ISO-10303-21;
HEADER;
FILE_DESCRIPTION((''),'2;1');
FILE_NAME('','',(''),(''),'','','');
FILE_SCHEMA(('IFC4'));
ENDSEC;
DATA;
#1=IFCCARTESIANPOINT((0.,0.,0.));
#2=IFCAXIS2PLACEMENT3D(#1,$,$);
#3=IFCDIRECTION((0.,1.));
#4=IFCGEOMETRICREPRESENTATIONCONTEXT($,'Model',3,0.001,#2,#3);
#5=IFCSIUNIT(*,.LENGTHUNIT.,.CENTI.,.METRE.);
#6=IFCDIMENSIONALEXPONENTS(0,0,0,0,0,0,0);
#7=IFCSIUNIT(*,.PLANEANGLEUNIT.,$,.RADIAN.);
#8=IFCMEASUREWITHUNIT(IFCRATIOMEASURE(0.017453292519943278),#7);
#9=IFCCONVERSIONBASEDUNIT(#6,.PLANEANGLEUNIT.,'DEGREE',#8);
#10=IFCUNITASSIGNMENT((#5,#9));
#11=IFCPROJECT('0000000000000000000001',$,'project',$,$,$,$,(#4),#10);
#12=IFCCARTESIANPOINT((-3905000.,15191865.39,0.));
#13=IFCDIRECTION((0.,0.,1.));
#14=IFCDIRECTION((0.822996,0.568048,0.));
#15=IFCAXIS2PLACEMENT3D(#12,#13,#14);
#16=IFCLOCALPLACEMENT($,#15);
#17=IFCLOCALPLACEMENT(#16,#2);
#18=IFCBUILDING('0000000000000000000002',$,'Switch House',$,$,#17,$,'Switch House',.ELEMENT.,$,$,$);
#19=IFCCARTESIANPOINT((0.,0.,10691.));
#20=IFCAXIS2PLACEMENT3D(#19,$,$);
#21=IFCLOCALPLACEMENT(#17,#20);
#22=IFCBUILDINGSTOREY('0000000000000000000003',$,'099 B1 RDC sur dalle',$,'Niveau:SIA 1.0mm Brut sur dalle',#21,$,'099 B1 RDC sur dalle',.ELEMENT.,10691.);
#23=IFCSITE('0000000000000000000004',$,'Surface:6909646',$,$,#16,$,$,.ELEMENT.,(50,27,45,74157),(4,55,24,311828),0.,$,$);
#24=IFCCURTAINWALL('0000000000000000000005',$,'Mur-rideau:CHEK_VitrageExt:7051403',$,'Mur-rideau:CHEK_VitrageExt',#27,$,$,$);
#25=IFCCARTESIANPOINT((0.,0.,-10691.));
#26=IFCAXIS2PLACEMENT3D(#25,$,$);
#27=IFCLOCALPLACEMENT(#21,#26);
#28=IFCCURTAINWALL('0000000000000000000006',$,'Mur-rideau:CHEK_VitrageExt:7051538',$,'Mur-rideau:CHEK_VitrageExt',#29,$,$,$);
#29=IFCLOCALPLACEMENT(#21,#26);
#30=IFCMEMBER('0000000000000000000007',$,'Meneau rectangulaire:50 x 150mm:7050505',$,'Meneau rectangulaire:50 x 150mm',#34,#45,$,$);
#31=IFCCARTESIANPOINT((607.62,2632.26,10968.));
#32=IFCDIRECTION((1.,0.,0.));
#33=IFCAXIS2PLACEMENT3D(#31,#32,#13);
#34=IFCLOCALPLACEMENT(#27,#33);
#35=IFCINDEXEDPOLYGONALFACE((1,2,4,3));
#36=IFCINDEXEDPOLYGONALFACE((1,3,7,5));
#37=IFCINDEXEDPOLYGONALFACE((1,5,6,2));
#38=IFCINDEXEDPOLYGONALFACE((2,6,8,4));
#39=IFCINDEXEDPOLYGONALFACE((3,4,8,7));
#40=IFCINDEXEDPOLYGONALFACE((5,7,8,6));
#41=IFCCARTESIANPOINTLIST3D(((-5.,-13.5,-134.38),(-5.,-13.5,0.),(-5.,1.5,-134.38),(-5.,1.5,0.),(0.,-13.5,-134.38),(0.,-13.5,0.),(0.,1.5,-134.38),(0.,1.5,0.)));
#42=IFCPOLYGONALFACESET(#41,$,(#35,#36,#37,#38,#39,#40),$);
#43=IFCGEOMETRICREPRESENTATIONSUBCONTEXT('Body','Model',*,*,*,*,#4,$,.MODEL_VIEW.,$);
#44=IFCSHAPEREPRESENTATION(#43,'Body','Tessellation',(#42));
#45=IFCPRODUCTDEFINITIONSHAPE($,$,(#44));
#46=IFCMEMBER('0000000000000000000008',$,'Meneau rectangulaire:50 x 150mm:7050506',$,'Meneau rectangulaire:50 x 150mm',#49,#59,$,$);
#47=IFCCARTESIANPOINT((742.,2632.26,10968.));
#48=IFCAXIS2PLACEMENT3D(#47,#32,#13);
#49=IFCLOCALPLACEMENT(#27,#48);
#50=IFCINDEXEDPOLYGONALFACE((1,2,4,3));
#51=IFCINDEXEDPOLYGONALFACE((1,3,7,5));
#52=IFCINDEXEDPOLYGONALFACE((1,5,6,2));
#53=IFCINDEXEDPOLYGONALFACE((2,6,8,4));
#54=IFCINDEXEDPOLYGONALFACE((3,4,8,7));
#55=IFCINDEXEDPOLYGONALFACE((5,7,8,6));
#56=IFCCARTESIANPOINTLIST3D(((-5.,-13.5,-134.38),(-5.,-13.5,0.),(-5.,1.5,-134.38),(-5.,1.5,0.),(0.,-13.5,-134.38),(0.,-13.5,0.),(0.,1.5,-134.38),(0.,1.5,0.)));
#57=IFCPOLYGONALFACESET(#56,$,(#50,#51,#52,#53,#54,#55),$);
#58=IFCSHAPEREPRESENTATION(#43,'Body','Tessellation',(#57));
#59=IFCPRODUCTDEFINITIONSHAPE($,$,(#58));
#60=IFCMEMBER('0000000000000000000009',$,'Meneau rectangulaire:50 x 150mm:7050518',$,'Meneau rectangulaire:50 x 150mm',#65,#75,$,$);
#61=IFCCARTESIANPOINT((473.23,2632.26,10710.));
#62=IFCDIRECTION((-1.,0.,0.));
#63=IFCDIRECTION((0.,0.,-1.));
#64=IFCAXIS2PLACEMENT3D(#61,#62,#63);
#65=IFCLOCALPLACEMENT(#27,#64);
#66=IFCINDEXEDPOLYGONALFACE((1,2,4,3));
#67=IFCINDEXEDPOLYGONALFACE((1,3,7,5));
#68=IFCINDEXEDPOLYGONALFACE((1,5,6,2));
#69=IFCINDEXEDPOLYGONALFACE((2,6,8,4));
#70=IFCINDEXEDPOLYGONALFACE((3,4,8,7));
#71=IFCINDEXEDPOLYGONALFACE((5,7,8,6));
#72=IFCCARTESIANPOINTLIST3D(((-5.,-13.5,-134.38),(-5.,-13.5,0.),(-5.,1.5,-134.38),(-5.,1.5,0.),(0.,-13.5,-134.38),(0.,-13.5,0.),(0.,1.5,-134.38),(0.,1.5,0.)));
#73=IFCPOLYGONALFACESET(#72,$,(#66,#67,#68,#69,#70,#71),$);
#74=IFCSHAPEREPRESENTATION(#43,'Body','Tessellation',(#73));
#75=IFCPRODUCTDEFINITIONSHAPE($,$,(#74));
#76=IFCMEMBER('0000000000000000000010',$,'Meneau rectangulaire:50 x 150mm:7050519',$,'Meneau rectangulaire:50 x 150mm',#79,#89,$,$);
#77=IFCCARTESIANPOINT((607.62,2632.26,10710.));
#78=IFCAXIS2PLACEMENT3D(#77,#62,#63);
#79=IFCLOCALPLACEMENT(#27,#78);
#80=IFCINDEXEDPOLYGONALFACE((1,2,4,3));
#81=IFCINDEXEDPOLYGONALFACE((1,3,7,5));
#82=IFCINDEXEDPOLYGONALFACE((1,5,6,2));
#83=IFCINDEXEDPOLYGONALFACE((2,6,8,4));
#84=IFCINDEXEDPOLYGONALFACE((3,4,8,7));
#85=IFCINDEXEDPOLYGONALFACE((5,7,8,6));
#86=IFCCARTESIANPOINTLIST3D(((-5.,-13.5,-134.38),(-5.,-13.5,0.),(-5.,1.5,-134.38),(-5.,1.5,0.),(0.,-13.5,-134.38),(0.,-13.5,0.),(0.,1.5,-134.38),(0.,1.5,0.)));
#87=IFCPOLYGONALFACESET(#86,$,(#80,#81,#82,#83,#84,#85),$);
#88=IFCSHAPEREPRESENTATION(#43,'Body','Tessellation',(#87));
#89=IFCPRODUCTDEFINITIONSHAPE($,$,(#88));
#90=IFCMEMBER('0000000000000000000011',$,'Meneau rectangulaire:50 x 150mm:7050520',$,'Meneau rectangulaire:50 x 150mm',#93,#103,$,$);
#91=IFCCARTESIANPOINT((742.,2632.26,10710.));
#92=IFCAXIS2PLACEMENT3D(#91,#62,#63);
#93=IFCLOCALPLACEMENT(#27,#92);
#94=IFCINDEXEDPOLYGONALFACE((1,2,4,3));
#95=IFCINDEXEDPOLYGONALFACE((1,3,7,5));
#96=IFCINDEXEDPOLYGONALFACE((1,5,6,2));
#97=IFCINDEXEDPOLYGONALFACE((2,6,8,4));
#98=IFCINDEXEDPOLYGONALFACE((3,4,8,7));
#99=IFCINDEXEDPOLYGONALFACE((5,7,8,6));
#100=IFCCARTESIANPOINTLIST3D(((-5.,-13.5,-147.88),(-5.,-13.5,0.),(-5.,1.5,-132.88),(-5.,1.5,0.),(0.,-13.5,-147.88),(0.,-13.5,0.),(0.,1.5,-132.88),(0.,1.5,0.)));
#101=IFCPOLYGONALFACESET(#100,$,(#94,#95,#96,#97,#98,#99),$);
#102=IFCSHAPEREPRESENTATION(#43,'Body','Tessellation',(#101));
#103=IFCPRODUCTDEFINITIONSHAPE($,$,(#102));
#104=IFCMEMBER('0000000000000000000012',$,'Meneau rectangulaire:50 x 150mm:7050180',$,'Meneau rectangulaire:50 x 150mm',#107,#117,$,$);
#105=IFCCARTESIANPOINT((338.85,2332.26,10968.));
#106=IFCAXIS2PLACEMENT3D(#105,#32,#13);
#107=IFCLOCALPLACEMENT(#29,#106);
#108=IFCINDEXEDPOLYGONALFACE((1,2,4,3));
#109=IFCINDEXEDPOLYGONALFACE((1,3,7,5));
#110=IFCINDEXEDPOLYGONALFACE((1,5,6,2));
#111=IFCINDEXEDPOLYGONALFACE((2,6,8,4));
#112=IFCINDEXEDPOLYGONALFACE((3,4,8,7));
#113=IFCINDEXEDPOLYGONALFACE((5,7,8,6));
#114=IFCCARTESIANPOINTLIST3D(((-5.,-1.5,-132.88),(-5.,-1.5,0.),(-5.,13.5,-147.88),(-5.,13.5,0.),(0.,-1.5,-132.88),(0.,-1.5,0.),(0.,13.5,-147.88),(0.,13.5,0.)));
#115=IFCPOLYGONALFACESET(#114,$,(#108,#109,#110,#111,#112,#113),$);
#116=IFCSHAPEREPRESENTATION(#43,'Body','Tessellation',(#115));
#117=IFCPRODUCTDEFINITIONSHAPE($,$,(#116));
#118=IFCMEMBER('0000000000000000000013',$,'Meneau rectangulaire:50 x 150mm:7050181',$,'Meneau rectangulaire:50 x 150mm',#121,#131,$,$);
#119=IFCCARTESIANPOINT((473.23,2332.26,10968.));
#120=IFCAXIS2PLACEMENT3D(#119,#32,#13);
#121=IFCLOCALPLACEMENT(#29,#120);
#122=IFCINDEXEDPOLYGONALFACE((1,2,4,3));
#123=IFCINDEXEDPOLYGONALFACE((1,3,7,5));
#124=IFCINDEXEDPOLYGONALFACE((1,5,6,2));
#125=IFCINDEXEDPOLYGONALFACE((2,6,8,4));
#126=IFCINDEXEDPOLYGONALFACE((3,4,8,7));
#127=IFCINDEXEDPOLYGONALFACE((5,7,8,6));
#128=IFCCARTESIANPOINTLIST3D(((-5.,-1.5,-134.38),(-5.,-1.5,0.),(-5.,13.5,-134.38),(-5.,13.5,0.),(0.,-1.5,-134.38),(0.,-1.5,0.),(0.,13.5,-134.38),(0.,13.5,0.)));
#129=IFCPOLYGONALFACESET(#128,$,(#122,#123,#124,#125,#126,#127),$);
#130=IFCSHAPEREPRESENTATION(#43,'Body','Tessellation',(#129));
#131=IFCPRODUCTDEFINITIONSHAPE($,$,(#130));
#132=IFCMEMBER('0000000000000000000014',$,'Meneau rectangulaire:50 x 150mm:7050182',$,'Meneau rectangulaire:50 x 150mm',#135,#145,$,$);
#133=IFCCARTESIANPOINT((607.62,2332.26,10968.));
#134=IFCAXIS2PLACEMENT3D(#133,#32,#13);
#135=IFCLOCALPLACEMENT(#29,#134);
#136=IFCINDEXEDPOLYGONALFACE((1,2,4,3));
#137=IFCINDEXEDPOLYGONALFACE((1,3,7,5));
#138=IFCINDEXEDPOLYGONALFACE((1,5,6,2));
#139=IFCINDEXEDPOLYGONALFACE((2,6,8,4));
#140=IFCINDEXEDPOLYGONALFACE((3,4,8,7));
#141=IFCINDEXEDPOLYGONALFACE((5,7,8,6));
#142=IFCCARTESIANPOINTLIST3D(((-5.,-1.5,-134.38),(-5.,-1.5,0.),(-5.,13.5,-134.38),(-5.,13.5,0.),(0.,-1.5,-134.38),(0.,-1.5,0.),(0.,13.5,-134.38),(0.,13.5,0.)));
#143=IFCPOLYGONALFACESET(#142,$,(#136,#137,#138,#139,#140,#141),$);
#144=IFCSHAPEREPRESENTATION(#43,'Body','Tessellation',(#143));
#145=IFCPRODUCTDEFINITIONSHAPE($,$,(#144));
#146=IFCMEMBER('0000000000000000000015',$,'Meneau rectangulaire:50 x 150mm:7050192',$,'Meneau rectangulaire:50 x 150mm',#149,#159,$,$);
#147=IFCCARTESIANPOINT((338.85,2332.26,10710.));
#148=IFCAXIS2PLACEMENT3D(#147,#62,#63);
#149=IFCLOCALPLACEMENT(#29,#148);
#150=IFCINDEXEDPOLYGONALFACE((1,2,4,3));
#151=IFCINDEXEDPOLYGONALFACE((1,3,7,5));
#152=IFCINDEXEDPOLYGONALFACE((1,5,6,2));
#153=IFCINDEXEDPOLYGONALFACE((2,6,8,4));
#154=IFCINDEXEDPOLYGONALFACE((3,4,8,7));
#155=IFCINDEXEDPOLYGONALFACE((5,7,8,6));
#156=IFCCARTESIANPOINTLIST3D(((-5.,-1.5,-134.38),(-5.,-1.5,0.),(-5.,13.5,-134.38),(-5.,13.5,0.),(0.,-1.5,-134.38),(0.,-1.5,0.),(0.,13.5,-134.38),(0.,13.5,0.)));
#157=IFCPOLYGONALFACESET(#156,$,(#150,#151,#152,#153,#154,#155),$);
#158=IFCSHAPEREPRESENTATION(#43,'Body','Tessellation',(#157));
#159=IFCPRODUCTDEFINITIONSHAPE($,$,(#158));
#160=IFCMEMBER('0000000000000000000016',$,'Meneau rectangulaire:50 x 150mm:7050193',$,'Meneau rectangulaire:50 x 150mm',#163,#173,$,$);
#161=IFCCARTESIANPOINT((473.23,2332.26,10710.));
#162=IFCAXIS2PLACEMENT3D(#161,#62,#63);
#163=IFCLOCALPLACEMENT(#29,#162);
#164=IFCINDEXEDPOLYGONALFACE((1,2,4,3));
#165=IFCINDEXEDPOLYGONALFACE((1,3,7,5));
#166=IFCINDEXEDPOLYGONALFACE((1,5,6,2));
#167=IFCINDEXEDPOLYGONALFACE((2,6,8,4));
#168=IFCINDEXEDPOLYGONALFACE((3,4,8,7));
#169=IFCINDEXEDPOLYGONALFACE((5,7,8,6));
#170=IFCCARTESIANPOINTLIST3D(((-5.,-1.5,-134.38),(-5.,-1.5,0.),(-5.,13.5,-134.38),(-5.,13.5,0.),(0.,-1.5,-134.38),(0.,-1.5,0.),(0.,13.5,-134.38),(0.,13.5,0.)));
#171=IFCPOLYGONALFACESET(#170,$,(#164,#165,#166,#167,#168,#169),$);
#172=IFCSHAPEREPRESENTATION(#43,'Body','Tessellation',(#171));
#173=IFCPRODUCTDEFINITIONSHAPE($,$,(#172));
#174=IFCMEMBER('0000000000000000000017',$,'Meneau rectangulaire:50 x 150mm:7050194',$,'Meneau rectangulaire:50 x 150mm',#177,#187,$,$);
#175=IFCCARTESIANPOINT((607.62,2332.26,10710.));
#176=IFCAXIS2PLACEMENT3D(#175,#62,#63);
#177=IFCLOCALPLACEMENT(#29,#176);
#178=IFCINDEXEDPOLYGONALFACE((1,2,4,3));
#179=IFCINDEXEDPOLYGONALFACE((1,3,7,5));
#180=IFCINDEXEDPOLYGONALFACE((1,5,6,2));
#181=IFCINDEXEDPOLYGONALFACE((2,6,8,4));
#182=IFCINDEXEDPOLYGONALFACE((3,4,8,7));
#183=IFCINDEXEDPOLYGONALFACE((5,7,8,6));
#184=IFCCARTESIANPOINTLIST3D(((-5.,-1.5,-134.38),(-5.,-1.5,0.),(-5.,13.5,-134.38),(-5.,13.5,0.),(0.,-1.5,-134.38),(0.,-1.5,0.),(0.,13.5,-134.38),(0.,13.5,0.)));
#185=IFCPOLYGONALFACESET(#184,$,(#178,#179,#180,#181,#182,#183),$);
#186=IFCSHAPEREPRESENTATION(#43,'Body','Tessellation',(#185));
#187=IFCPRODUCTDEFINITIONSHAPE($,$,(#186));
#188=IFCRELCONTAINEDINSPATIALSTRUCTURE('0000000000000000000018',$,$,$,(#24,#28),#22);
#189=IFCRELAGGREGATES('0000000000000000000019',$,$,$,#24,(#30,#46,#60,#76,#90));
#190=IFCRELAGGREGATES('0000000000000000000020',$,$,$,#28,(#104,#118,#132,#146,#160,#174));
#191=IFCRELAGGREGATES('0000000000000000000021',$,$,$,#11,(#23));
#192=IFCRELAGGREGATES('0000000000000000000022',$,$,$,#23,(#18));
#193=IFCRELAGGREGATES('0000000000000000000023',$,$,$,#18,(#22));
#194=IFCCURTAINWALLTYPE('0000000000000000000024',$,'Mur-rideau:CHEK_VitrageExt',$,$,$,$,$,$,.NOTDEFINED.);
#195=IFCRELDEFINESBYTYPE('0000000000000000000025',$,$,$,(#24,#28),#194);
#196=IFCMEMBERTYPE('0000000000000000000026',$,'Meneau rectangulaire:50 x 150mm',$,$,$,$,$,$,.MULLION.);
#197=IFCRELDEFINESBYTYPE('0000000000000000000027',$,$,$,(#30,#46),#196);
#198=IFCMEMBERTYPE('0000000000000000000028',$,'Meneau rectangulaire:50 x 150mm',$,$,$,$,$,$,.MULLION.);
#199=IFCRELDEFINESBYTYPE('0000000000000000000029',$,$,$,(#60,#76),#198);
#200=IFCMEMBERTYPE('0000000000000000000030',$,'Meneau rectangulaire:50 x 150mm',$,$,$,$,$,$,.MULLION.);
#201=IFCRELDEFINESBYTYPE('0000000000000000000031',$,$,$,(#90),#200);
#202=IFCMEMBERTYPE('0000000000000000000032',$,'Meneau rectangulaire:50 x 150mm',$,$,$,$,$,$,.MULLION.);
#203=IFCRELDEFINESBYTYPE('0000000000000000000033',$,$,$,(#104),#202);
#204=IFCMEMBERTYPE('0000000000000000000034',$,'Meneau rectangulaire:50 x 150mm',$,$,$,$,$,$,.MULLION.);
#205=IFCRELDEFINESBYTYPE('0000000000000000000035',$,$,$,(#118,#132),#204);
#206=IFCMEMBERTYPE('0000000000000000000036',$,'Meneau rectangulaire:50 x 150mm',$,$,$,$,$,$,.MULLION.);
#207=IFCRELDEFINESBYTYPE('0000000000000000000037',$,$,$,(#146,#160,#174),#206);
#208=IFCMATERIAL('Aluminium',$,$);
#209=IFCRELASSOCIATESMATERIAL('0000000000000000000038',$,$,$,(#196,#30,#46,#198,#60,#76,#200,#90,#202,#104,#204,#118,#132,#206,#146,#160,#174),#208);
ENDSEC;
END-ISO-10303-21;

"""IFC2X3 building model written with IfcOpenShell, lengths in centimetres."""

from ifc_helpers import new_model, entity, si_unit, converted_unit, direction, frame, origin, origin_2d_with_axis, place, context, subcontext, project, spatial, rectangle, extrude, clip, halfspace, source, transform, mapped, material, type_object, type_shapes, element, aggregate, save


model = new_model("IFC2X3")

# Units and contexts
model_context = context("Model", 3, precision=0.001, world=origin(), true_north=direction((0.0, 1.0)))
body_context = subcontext(model_context, "Body", "Model", "MODEL_VIEW")
ifc_project = project(units=[si_unit("LENGTHUNIT", "METRE", prefix="CENTI"), converted_unit("PLANEANGLEUNIT", "DEGREE", entity("IfcRatioMeasure", 0.017453292519943278), si_unit("PLANEANGLEUNIT", "RADIAN"), dimensions=[0, 0, 0, 0, 0, 0, 0])], contexts=[model_context])

# Site, building, storey
site_placement = place(None, frame((-3905000.0, 15191865.39, 0.0), z_axis=(0.0, 0.0, 1.0), x_axis=(0.822996, 0.568048, 0.0)))
site = spatial("IfcSite", under=ifc_project, at=site_placement, Name="Surface:6909646", CompositionType="ELEMENT", RefLatitude=(50, 27, 45, 74157), RefLongitude=(4, 55, 24, 311828), RefElevation=0.0)
building_placement = place(site_placement, origin())
building = spatial("IfcBuilding", under=site, at=building_placement, Name="Switch House", LongName="Switch House", CompositionType="ELEMENT")
storey_placement = place(building_placement, frame((0.0, 0.0, 10691.0)))
storey = spatial("IfcBuildingStorey", under=building, at=storey_placement, Name="099 B1 RDC sur dalle", ObjectType="Niveau:SIA 1.0mm Brut sur dalle", LongName="099 B1 RDC sur dalle", CompositionType="ELEMENT", Elevation=10691.0)

# Shared definitions
curtain_wall_type = type_object("IfcCurtainWallType", Name="Mur-rideau:CHEK_VitrageExt", PredefinedType="NOTDEFINED")
ifc_material_1 = material(Name="Aluminium")

# Curtain walls
curtain_wall_1_placement = place(storey_placement, frame((0.0, 0.0, -10691.0)))
curtain_wall_1 = element("IfcCurtainWall", 1, at=curtain_wall_1_placement, inside=storey, type_object=curtain_wall_type, Name="Mur-rideau:CHEK_VitrageExt:7051403", ObjectType="Mur-rideau:CHEK_VitrageExt")
curtain_wall_2_placement = place(storey_placement, frame((0.0, 0.0, -10691.0)))
curtain_wall_2 = element("IfcCurtainWall", 2, at=curtain_wall_2_placement, inside=storey, type_object=curtain_wall_type, Name="Mur-rideau:CHEK_VitrageExt:7051538", ObjectType="Mur-rideau:CHEK_VitrageExt")

# Members
member_type_1 = type_object("IfcMemberType", Name="Meneau rectangulaire:50 x 150mm", PredefinedType="MULLION", material=ifc_material_1)
shared_shape_1 = source(origin(), body_context, "Body", "SweptSolid", [
    extrude(rectangle(XDim=15.0, YDim=5.0, at=origin_2d_with_axis()), frame((-2.5, -6.0, -134.38), z_axis=(0.0, 0.0, 1.0), x_axis=(0.0, -1.0, 0.0)), (0.0, 0.0, 1.0), 134.38),
])
type_shapes(member_type_1, [shared_shape_1])
member_1_placement = place(curtain_wall_1_placement, frame((607.62, 2632.26, 10968.0), z_axis=(1.0, 0.0, 0.0), x_axis=(0.0, 0.0, 1.0)))
member_1 = element("IfcMember", 3, at=member_1_placement, type_object=member_type_1, material=ifc_material_1, Name="Meneau rectangulaire:50 x 150mm:7050505", ObjectType="Meneau rectangulaire:50 x 150mm", context=body_context, shape_type="MappedRepresentation", body=[
    mapped(shared_shape_1, transform((0.0, 0.0, 0.0), scale=1.0)),
])
member_2_placement = place(curtain_wall_1_placement, frame((742.0, 2632.26, 10968.0), z_axis=(1.0, 0.0, 0.0), x_axis=(0.0, 0.0, 1.0)))
member_2 = element("IfcMember", 4, at=member_2_placement, type_object=member_type_1, material=ifc_material_1, Name="Meneau rectangulaire:50 x 150mm:7050506", ObjectType="Meneau rectangulaire:50 x 150mm", context=body_context, shape_type="MappedRepresentation", body=[
    mapped(shared_shape_1, transform((0.0, 0.0, 0.0), scale=1.0)),
])
member_type_2 = type_object("IfcMemberType", Name="Meneau rectangulaire:50 x 150mm", PredefinedType="MULLION", material=ifc_material_1)
shared_shape_2 = source(origin(), body_context, "Body", "SweptSolid", [
    extrude(rectangle(XDim=15.0, YDim=5.0, at=origin_2d_with_axis()), frame((-2.5, -6.0, -134.38), z_axis=(0.0, 0.0, 1.0), x_axis=(0.0, -1.0, 0.0)), (0.0, 0.0, 1.0), 134.38),
])
type_shapes(member_type_2, [shared_shape_2])
member_3_placement = place(curtain_wall_1_placement, frame((473.23, 2632.26, 10710.0), z_axis=(-1.0, 0.0, 0.0), x_axis=(0.0, 0.0, -1.0)))
member_3 = element("IfcMember", 5, at=member_3_placement, type_object=member_type_2, material=ifc_material_1, Name="Meneau rectangulaire:50 x 150mm:7050518", ObjectType="Meneau rectangulaire:50 x 150mm", context=body_context, shape_type="MappedRepresentation", body=[
    mapped(shared_shape_2, transform((0.0, 0.0, 0.0), scale=1.0)),
])
member_4_placement = place(curtain_wall_1_placement, frame((607.62, 2632.26, 10710.0), z_axis=(-1.0, 0.0, 0.0), x_axis=(0.0, 0.0, -1.0)))
member_4 = element("IfcMember", 6, at=member_4_placement, type_object=member_type_2, material=ifc_material_1, Name="Meneau rectangulaire:50 x 150mm:7050519", ObjectType="Meneau rectangulaire:50 x 150mm", context=body_context, shape_type="MappedRepresentation", body=[
    mapped(shared_shape_2, transform((0.0, 0.0, 0.0), scale=1.0)),
])
member_type_3 = type_object("IfcMemberType", Name="Meneau rectangulaire:50 x 150mm", PredefinedType="MULLION", material=ifc_material_1)
shared_shape_3 = source(origin(), body_context, "Body", "SweptSolid", [
    clip(extrude(rectangle(XDim=15.0, YDim=5.0, at=origin_2d_with_axis()), frame((-2.5, -6.0, -147.88), z_axis=(0.0, 0.0, 1.0), x_axis=(0.0, -1.0, 0.0)), (0.0, 0.0, 1.0), 147.88), halfspace(frame((-30.48, 0.0, -134.38), z_axis=(0.0, 0.707107, -0.707107), x_axis=(0.0, 0.707107, 0.707107)), False)),
])
type_shapes(member_type_3, [shared_shape_3])
member_5_placement = place(curtain_wall_1_placement, frame((742.0, 2632.26, 10710.0), z_axis=(-1.0, 0.0, 0.0), x_axis=(0.0, 0.0, -1.0)))
member_5 = element("IfcMember", 7, at=member_5_placement, type_object=member_type_3, material=ifc_material_1, Name="Meneau rectangulaire:50 x 150mm:7050520", ObjectType="Meneau rectangulaire:50 x 150mm", context=body_context, shape_type="MappedRepresentation", body=[
    mapped(shared_shape_3, transform((0.0, 0.0, 0.0), scale=1.0)),
])
member_type_4 = type_object("IfcMemberType", Name="Meneau rectangulaire:50 x 150mm", PredefinedType="MULLION", material=ifc_material_1)
shared_shape_4 = source(origin(), body_context, "Body", "SweptSolid", [
    clip(extrude(rectangle(XDim=15.0, YDim=5.0, at=origin_2d_with_axis()), frame((-2.5, 6.0, -147.88), z_axis=(0.0, 0.0, 1.0), x_axis=(0.0, -1.0, 0.0)), (0.0, 0.0, 1.0), 147.88), halfspace(frame((30.48, 0.0, -134.38), z_axis=(0.0, -0.707107, -0.707107), x_axis=(0.0, -0.707107, 0.707107)), False)),
])
type_shapes(member_type_4, [shared_shape_4])
member_6_placement = place(curtain_wall_2_placement, frame((338.85, 2332.26, 10968.0), z_axis=(1.0, 0.0, 0.0), x_axis=(0.0, 0.0, 1.0)))
member_6 = element("IfcMember", 8, at=member_6_placement, type_object=member_type_4, material=ifc_material_1, Name="Meneau rectangulaire:50 x 150mm:7050180", ObjectType="Meneau rectangulaire:50 x 150mm", context=body_context, shape_type="MappedRepresentation", body=[
    mapped(shared_shape_4, transform((0.0, 0.0, 0.0), scale=1.0)),
])
member_type_5 = type_object("IfcMemberType", Name="Meneau rectangulaire:50 x 150mm", PredefinedType="MULLION", material=ifc_material_1)
shared_shape_5 = source(origin(), body_context, "Body", "SweptSolid", [
    extrude(rectangle(XDim=15.0, YDim=5.0, at=origin_2d_with_axis()), frame((-2.5, 6.0, -134.38), z_axis=(0.0, 0.0, 1.0), x_axis=(0.0, -1.0, 0.0)), (0.0, 0.0, 1.0), 134.38),
])
type_shapes(member_type_5, [shared_shape_5])
member_7_placement = place(curtain_wall_2_placement, frame((473.23, 2332.26, 10968.0), z_axis=(1.0, 0.0, 0.0), x_axis=(0.0, 0.0, 1.0)))
member_7 = element("IfcMember", 9, at=member_7_placement, type_object=member_type_5, material=ifc_material_1, Name="Meneau rectangulaire:50 x 150mm:7050181", ObjectType="Meneau rectangulaire:50 x 150mm", context=body_context, shape_type="MappedRepresentation", body=[
    mapped(shared_shape_5, transform((0.0, 0.0, 0.0), scale=1.0)),
])
member_8_placement = place(curtain_wall_2_placement, frame((607.62, 2332.26, 10968.0), z_axis=(1.0, 0.0, 0.0), x_axis=(0.0, 0.0, 1.0)))
member_8 = element("IfcMember", 10, at=member_8_placement, type_object=member_type_5, material=ifc_material_1, Name="Meneau rectangulaire:50 x 150mm:7050182", ObjectType="Meneau rectangulaire:50 x 150mm", context=body_context, shape_type="MappedRepresentation", body=[
    mapped(shared_shape_5, transform((0.0, 0.0, 0.0), scale=1.0)),
])
member_type_6 = type_object("IfcMemberType", Name="Meneau rectangulaire:50 x 150mm", PredefinedType="MULLION", material=ifc_material_1)
shared_shape_6 = source(origin(), body_context, "Body", "SweptSolid", [
    extrude(rectangle(XDim=15.0, YDim=5.0, at=origin_2d_with_axis()), frame((-2.5, 6.0, -134.38), z_axis=(0.0, 0.0, 1.0), x_axis=(0.0, -1.0, 0.0)), (0.0, 0.0, 1.0), 134.38),
])
type_shapes(member_type_6, [shared_shape_6])
member_9_placement = place(curtain_wall_2_placement, frame((338.85, 2332.26, 10710.0), z_axis=(-1.0, 0.0, 0.0), x_axis=(0.0, 0.0, -1.0)))
member_9 = element("IfcMember", 11, at=member_9_placement, type_object=member_type_6, material=ifc_material_1, Name="Meneau rectangulaire:50 x 150mm:7050192", ObjectType="Meneau rectangulaire:50 x 150mm", context=body_context, shape_type="MappedRepresentation", body=[
    mapped(shared_shape_6, transform((0.0, 0.0, 0.0), scale=1.0)),
])
member_10_placement = place(curtain_wall_2_placement, frame((473.23, 2332.26, 10710.0), z_axis=(-1.0, 0.0, 0.0), x_axis=(0.0, 0.0, -1.0)))
member_10 = element("IfcMember", 12, at=member_10_placement, type_object=member_type_6, material=ifc_material_1, Name="Meneau rectangulaire:50 x 150mm:7050193", ObjectType="Meneau rectangulaire:50 x 150mm", context=body_context, shape_type="MappedRepresentation", body=[
    mapped(shared_shape_6, transform((0.0, 0.0, 0.0), scale=1.0)),
])
member_11_placement = place(curtain_wall_2_placement, frame((607.62, 2332.26, 10710.0), z_axis=(-1.0, 0.0, 0.0), x_axis=(0.0, 0.0, -1.0)))
member_11 = element("IfcMember", 13, at=member_11_placement, type_object=member_type_6, material=ifc_material_1, Name="Meneau rectangulaire:50 x 150mm:7050194", ObjectType="Meneau rectangulaire:50 x 150mm", context=body_context, shape_type="MappedRepresentation", body=[
    mapped(shared_shape_6, transform((0.0, 0.0, 0.0), scale=1.0)),
])

aggregate(curtain_wall_1, [member_1, member_2, member_3, member_4, member_5])
aggregate(curtain_wall_2, [member_6, member_7, member_8, member_9, member_10, member_11])

save(model, "model.ifc")
